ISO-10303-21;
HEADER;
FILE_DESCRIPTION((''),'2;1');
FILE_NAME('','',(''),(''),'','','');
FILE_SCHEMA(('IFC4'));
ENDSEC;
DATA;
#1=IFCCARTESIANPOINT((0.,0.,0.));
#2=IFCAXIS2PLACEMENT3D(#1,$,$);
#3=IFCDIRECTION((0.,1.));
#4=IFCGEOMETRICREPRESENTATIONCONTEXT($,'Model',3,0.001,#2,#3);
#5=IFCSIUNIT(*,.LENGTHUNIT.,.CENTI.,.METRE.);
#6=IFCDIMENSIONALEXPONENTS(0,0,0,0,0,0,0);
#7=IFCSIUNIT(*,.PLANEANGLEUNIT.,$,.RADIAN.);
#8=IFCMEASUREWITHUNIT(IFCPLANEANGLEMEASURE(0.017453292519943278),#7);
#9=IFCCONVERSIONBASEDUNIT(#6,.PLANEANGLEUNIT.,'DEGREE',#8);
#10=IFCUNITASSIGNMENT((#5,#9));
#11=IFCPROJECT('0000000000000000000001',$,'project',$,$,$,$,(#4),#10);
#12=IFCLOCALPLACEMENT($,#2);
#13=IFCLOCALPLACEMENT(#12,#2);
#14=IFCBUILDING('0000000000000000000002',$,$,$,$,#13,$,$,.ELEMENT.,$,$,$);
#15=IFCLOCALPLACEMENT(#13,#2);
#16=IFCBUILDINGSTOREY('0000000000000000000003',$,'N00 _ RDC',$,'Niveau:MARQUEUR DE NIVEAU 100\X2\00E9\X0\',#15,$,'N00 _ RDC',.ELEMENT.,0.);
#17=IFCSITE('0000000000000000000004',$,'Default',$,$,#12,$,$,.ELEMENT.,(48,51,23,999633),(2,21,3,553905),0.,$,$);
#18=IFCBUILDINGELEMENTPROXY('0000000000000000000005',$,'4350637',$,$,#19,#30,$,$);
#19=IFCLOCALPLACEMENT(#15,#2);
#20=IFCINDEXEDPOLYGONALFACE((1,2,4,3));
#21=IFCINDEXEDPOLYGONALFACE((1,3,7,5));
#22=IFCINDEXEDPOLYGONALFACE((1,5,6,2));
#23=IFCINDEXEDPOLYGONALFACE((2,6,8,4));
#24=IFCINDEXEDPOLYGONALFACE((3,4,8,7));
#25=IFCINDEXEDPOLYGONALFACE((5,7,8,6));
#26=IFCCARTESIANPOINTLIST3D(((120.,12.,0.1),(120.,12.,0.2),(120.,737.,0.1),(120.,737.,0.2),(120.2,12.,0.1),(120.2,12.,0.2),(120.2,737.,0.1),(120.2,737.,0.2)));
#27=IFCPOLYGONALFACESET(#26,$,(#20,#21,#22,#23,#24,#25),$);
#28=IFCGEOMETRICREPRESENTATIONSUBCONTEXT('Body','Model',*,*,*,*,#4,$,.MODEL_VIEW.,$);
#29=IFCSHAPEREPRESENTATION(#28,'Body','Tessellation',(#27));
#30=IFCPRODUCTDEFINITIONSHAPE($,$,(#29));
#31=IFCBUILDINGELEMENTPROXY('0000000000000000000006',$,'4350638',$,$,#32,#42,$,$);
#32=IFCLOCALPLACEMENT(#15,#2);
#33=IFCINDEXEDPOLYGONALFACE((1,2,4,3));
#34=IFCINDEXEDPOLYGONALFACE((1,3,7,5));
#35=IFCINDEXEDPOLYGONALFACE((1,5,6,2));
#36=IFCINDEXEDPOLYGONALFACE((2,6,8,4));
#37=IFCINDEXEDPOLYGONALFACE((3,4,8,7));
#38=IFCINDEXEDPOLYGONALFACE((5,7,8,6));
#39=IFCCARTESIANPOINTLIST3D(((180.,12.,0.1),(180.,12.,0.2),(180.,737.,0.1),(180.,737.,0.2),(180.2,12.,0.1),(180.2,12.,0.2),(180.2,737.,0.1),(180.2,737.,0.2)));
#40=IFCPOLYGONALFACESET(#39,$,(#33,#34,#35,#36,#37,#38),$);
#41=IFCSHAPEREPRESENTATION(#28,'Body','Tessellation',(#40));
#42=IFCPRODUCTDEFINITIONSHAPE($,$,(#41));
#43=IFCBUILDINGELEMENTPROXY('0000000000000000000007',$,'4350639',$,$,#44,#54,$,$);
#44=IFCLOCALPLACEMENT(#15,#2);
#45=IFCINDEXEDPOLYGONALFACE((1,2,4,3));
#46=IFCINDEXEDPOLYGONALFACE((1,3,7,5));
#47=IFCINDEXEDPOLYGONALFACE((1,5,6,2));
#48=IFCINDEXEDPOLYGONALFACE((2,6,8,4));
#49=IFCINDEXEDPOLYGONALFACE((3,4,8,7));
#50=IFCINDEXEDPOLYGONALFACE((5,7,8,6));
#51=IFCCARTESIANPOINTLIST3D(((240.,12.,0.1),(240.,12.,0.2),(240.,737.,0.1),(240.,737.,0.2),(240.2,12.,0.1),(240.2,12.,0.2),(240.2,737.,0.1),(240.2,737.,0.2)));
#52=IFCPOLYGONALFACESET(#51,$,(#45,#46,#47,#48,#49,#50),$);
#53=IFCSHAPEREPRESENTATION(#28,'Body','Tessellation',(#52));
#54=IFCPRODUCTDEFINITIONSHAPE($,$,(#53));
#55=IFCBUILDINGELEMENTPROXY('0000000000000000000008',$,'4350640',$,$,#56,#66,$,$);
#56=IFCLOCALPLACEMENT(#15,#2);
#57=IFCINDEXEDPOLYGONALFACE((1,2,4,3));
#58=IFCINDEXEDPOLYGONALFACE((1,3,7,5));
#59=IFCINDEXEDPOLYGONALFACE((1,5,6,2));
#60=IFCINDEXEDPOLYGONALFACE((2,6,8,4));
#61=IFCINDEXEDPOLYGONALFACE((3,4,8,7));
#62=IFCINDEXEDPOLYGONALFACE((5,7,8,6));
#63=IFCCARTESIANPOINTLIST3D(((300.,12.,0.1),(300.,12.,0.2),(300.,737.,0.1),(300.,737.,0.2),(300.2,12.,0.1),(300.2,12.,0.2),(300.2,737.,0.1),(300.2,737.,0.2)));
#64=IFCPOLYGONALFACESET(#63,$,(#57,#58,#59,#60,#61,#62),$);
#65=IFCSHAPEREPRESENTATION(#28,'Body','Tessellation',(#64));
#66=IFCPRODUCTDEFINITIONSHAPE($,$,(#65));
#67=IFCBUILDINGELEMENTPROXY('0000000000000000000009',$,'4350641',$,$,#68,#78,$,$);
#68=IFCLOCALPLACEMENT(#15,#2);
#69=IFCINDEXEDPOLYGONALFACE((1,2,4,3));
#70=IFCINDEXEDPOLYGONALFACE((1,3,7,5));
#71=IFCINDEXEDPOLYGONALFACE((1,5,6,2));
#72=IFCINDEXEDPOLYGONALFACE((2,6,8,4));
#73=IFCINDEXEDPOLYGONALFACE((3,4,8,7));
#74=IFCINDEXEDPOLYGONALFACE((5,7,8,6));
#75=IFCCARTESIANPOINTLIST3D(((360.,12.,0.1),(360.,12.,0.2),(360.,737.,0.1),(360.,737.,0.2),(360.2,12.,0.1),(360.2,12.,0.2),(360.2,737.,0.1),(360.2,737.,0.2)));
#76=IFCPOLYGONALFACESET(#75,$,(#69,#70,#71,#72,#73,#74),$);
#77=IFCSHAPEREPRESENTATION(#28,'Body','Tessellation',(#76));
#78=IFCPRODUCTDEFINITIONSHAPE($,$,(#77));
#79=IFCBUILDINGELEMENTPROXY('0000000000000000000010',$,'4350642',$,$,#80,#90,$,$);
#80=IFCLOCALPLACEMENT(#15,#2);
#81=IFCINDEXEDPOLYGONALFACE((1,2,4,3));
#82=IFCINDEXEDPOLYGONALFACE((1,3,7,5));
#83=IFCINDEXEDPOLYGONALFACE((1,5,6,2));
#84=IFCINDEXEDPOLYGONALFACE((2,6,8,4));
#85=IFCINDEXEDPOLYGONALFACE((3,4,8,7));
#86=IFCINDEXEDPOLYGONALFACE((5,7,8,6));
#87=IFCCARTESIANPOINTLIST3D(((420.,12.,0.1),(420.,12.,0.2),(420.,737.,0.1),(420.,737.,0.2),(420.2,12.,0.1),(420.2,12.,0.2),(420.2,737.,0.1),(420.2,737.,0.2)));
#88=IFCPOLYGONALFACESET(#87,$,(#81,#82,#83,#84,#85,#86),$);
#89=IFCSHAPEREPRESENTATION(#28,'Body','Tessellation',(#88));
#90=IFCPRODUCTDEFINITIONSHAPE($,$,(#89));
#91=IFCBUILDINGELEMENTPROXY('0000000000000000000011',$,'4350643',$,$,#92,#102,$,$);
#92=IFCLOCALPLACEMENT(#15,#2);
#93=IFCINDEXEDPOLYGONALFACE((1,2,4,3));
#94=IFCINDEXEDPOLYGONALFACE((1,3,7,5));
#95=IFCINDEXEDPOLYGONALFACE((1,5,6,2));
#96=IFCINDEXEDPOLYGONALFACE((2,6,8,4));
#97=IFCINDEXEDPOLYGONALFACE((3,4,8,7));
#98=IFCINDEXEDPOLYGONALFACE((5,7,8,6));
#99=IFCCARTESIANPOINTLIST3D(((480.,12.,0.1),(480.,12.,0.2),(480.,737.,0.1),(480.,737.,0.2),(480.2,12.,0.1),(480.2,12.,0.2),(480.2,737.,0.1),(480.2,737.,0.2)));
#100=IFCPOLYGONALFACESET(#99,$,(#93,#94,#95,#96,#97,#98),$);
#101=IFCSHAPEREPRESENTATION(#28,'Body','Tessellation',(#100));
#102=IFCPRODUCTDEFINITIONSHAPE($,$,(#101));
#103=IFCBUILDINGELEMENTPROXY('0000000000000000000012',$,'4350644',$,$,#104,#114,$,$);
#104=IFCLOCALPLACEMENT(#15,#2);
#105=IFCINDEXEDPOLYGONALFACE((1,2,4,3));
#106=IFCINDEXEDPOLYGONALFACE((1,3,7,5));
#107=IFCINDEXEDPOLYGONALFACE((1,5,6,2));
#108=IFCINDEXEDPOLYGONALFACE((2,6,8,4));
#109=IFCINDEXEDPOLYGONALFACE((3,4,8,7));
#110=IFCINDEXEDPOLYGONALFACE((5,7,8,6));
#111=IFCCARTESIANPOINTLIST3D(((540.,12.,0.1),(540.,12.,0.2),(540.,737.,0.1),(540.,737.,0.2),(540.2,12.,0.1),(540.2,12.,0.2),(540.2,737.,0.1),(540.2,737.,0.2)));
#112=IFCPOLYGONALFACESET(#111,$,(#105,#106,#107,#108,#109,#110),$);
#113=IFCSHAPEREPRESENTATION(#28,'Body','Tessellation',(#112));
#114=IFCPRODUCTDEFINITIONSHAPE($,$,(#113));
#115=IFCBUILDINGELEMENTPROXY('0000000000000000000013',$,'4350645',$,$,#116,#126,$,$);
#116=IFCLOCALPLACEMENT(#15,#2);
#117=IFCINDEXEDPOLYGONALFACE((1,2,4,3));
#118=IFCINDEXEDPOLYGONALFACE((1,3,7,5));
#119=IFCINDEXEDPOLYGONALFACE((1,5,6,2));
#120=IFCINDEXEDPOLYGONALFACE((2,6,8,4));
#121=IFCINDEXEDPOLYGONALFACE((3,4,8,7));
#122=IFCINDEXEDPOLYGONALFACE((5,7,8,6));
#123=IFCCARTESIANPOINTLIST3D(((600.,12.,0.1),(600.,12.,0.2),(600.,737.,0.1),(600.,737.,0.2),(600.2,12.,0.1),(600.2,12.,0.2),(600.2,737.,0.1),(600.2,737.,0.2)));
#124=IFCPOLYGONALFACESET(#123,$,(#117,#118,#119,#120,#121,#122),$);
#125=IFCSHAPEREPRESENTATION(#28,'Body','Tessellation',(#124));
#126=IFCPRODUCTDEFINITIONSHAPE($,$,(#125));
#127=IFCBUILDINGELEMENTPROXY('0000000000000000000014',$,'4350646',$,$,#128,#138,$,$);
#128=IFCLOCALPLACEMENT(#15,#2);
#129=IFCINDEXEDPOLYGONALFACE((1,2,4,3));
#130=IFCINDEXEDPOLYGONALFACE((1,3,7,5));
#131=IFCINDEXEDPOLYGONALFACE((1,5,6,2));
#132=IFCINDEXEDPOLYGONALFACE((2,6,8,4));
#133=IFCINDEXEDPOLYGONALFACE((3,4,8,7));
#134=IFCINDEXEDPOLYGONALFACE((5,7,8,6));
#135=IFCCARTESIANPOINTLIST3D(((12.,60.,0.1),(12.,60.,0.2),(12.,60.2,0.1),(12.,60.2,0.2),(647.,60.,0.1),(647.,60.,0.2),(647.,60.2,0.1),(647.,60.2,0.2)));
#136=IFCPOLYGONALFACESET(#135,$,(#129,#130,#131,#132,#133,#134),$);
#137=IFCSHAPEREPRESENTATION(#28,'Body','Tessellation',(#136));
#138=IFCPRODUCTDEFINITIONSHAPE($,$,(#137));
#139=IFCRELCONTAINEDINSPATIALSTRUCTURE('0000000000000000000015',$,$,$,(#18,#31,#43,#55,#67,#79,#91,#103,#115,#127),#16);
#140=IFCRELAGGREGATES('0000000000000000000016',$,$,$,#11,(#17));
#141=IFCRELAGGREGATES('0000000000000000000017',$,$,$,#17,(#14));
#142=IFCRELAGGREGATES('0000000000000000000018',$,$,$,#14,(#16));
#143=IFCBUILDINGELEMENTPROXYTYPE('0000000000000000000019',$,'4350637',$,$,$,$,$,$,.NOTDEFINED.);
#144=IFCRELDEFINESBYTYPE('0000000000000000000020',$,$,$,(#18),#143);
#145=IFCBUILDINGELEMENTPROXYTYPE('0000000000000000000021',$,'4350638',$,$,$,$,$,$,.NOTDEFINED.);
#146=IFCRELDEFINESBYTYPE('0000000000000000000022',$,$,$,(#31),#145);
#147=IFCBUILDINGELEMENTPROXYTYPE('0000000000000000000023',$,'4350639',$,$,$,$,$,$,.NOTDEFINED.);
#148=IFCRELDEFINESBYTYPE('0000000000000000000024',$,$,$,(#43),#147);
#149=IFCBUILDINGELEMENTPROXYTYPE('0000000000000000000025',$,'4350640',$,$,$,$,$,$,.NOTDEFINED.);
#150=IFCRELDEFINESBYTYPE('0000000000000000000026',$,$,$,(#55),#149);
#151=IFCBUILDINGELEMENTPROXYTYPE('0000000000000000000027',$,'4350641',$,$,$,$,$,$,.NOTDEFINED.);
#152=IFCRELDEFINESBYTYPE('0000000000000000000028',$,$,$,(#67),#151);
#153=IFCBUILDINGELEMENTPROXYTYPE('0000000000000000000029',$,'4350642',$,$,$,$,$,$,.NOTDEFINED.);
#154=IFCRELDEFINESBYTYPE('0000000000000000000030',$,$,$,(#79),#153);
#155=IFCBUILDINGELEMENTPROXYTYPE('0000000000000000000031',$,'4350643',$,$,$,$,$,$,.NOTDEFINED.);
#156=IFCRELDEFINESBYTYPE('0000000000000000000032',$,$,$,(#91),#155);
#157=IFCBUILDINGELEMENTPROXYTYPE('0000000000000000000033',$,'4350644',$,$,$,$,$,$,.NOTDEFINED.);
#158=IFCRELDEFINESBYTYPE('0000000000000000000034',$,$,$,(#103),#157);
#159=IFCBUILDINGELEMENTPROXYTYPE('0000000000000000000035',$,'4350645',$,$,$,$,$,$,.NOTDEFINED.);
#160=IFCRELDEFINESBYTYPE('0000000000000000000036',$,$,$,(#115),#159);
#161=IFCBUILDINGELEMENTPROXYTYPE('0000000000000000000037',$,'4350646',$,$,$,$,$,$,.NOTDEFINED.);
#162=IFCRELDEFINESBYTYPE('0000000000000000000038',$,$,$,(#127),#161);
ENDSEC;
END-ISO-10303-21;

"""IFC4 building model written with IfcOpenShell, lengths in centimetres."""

from ifc_helpers import new_model, entity, si_unit, converted_unit, direction, frame, frame_2d, origin, origin_2d_with_axis, place, context, subcontext, project, spatial, rectangle, extrude, type_object, element, save


model = new_model("IFC4")

# Units and contexts
model_context = context("Model", 3, precision=0.001, world=origin(), true_north=direction((0.0, 1.0)))
body_context = subcontext(model_context, "Body", "Model", "MODEL_VIEW")
ifc_project = project(units=[si_unit("LENGTHUNIT", "METRE", prefix="CENTI"), converted_unit("PLANEANGLEUNIT", "DEGREE", entity("IfcPlaneAngleMeasure", 0.017453292519943278), si_unit("PLANEANGLEUNIT", "RADIAN"), dimensions=[0, 0, 0, 0, 0, 0, 0])], contexts=[model_context])

# Site, building, storey
site_placement = place(None, origin())
site = spatial("IfcSite", under=ifc_project, at=site_placement, Name="Default", CompositionType="ELEMENT", RefLatitude=(48, 51, 23, 999633), RefLongitude=(2, 21, 3, 553905), RefElevation=0.0)
building_placement = place(site_placement, origin())
building = spatial("IfcBuilding", under=site, at=building_placement, CompositionType="ELEMENT")
storey_placement = place(building_placement, origin())
storey = spatial("IfcBuildingStorey", under=building, at=storey_placement, Name="N00 _ RDC", ObjectType="Niveau:MARQUEUR DE NIVEAU 100é", LongName="N00 _ RDC", CompositionType="ELEMENT", Elevation=0.0)

# Building element proxies
building_element_proxy_type_1 = type_object("IfcBuildingElementProxyType", Name="4350637", PredefinedType="NOTDEFINED")
proxy_1_placement = place(storey_placement, origin())
element("IfcBuildingElementProxy", 1, at=proxy_1_placement, inside=storey, type_object=building_element_proxy_type_1, Name="4350637", context=body_context, shape_type="SweptSolid", body=[
    extrude(rectangle(XDim=0.2, YDim=725.0, at=frame_2d((0.0, 0.0), x_axis=(1.0, 0.0))), frame((120.1, 374.5, 0.1)), (0.0, 0.0, 1.0), 0.1),
])
building_element_proxy_type_2 = type_object("IfcBuildingElementProxyType", Name="4350638", PredefinedType="NOTDEFINED")
proxy_2_placement = place(storey_placement, origin())
element("IfcBuildingElementProxy", 2, at=proxy_2_placement, inside=storey, type_object=building_element_proxy_type_2, Name="4350638", context=body_context, shape_type="SweptSolid", body=[
    extrude(rectangle(XDim=0.2, YDim=725.0, at=origin_2d_with_axis()), frame((180.1, 374.5, 0.1)), (0.0, 0.0, 1.0), 0.1),
])
building_element_proxy_type_3 = type_object("IfcBuildingElementProxyType", Name="4350639", PredefinedType="NOTDEFINED")
proxy_3_placement = place(storey_placement, origin())
element("IfcBuildingElementProxy", 3, at=proxy_3_placement, inside=storey, type_object=building_element_proxy_type_3, Name="4350639", context=body_context, shape_type="SweptSolid", body=[
    extrude(rectangle(XDim=0.2, YDim=725.0, at=frame_2d((0.0, 0.0), x_axis=(1.0, 0.0))), frame((240.1, 374.5, 0.1)), (0.0, 0.0, 1.0), 0.1),
])
building_element_proxy_type_4 = type_object("IfcBuildingElementProxyType", Name="4350640", PredefinedType="NOTDEFINED")
proxy_4_placement = place(storey_placement, origin())
element("IfcBuildingElementProxy", 4, at=proxy_4_placement, inside=storey, type_object=building_element_proxy_type_4, Name="4350640", context=body_context, shape_type="SweptSolid", body=[
    extrude(rectangle(XDim=0.2, YDim=725.0, at=origin_2d_with_axis()), frame((300.1, 374.5, 0.1)), (0.0, 0.0, 1.0), 0.1),
])
building_element_proxy_type_5 = type_object("IfcBuildingElementProxyType", Name="4350641", PredefinedType="NOTDEFINED")
proxy_5_placement = place(storey_placement, origin())
element("IfcBuildingElementProxy", 5, at=proxy_5_placement, inside=storey, type_object=building_element_proxy_type_5, Name="4350641", context=body_context, shape_type="SweptSolid", body=[
    extrude(rectangle(XDim=0.2, YDim=725.0, at=origin_2d_with_axis()), frame((360.1, 374.5, 0.1)), (0.0, 0.0, 1.0), 0.1),
])
building_element_proxy_type_6 = type_object("IfcBuildingElementProxyType", Name="4350642", PredefinedType="NOTDEFINED")
proxy_6_placement = place(storey_placement, origin())
element("IfcBuildingElementProxy", 6, at=proxy_6_placement, inside=storey, type_object=building_element_proxy_type_6, Name="4350642", context=body_context, shape_type="SweptSolid", body=[
    extrude(rectangle(XDim=0.2, YDim=725.0, at=origin_2d_with_axis()), frame((420.1, 374.5, 0.1)), (0.0, 0.0, 1.0), 0.1),
])
building_element_proxy_type_7 = type_object("IfcBuildingElementProxyType", Name="4350643", PredefinedType="NOTDEFINED")
proxy_7_placement = place(storey_placement, origin())
element("IfcBuildingElementProxy", 7, at=proxy_7_placement, inside=storey, type_object=building_element_proxy_type_7, Name="4350643", context=body_context, shape_type="SweptSolid", body=[
    extrude(rectangle(XDim=0.2, YDim=725.0, at=origin_2d_with_axis()), frame((480.1, 374.5, 0.1)), (0.0, 0.0, 1.0), 0.1),
])
building_element_proxy_type_8 = type_object("IfcBuildingElementProxyType", Name="4350644", PredefinedType="NOTDEFINED")
proxy_8_placement = place(storey_placement, origin())
element("IfcBuildingElementProxy", 8, at=proxy_8_placement, inside=storey, type_object=building_element_proxy_type_8, Name="4350644", context=body_context, shape_type="SweptSolid", body=[
    extrude(rectangle(XDim=0.2, YDim=725.0, at=origin_2d_with_axis()), frame((540.1, 374.5, 0.1)), (0.0, 0.0, 1.0), 0.1),
])
building_element_proxy_type_9 = type_object("IfcBuildingElementProxyType", Name="4350645", PredefinedType="NOTDEFINED")
proxy_9_placement = place(storey_placement, origin())
element("IfcBuildingElementProxy", 9, at=proxy_9_placement, inside=storey, type_object=building_element_proxy_type_9, Name="4350645", context=body_context, shape_type="SweptSolid", body=[
    extrude(rectangle(XDim=0.2, YDim=725.0, at=origin_2d_with_axis()), frame((600.1, 374.5, 0.1)), (0.0, 0.0, 1.0), 0.1),
])
building_element_proxy_type_10 = type_object("IfcBuildingElementProxyType", Name="4350646", PredefinedType="NOTDEFINED")
proxy_10_placement = place(storey_placement, origin())
element("IfcBuildingElementProxy", 10, at=proxy_10_placement, inside=storey, type_object=building_element_proxy_type_10, Name="4350646", context=body_context, shape_type="SweptSolid", body=[
    extrude(rectangle(XDim=635.0, YDim=0.2, at=frame_2d((0.0, 0.0), x_axis=(1.0, 0.0))), frame((329.5, 60.1, 0.1)), (0.0, 0.0, 1.0), 0.1),
])

save(model, "model.ifc")
